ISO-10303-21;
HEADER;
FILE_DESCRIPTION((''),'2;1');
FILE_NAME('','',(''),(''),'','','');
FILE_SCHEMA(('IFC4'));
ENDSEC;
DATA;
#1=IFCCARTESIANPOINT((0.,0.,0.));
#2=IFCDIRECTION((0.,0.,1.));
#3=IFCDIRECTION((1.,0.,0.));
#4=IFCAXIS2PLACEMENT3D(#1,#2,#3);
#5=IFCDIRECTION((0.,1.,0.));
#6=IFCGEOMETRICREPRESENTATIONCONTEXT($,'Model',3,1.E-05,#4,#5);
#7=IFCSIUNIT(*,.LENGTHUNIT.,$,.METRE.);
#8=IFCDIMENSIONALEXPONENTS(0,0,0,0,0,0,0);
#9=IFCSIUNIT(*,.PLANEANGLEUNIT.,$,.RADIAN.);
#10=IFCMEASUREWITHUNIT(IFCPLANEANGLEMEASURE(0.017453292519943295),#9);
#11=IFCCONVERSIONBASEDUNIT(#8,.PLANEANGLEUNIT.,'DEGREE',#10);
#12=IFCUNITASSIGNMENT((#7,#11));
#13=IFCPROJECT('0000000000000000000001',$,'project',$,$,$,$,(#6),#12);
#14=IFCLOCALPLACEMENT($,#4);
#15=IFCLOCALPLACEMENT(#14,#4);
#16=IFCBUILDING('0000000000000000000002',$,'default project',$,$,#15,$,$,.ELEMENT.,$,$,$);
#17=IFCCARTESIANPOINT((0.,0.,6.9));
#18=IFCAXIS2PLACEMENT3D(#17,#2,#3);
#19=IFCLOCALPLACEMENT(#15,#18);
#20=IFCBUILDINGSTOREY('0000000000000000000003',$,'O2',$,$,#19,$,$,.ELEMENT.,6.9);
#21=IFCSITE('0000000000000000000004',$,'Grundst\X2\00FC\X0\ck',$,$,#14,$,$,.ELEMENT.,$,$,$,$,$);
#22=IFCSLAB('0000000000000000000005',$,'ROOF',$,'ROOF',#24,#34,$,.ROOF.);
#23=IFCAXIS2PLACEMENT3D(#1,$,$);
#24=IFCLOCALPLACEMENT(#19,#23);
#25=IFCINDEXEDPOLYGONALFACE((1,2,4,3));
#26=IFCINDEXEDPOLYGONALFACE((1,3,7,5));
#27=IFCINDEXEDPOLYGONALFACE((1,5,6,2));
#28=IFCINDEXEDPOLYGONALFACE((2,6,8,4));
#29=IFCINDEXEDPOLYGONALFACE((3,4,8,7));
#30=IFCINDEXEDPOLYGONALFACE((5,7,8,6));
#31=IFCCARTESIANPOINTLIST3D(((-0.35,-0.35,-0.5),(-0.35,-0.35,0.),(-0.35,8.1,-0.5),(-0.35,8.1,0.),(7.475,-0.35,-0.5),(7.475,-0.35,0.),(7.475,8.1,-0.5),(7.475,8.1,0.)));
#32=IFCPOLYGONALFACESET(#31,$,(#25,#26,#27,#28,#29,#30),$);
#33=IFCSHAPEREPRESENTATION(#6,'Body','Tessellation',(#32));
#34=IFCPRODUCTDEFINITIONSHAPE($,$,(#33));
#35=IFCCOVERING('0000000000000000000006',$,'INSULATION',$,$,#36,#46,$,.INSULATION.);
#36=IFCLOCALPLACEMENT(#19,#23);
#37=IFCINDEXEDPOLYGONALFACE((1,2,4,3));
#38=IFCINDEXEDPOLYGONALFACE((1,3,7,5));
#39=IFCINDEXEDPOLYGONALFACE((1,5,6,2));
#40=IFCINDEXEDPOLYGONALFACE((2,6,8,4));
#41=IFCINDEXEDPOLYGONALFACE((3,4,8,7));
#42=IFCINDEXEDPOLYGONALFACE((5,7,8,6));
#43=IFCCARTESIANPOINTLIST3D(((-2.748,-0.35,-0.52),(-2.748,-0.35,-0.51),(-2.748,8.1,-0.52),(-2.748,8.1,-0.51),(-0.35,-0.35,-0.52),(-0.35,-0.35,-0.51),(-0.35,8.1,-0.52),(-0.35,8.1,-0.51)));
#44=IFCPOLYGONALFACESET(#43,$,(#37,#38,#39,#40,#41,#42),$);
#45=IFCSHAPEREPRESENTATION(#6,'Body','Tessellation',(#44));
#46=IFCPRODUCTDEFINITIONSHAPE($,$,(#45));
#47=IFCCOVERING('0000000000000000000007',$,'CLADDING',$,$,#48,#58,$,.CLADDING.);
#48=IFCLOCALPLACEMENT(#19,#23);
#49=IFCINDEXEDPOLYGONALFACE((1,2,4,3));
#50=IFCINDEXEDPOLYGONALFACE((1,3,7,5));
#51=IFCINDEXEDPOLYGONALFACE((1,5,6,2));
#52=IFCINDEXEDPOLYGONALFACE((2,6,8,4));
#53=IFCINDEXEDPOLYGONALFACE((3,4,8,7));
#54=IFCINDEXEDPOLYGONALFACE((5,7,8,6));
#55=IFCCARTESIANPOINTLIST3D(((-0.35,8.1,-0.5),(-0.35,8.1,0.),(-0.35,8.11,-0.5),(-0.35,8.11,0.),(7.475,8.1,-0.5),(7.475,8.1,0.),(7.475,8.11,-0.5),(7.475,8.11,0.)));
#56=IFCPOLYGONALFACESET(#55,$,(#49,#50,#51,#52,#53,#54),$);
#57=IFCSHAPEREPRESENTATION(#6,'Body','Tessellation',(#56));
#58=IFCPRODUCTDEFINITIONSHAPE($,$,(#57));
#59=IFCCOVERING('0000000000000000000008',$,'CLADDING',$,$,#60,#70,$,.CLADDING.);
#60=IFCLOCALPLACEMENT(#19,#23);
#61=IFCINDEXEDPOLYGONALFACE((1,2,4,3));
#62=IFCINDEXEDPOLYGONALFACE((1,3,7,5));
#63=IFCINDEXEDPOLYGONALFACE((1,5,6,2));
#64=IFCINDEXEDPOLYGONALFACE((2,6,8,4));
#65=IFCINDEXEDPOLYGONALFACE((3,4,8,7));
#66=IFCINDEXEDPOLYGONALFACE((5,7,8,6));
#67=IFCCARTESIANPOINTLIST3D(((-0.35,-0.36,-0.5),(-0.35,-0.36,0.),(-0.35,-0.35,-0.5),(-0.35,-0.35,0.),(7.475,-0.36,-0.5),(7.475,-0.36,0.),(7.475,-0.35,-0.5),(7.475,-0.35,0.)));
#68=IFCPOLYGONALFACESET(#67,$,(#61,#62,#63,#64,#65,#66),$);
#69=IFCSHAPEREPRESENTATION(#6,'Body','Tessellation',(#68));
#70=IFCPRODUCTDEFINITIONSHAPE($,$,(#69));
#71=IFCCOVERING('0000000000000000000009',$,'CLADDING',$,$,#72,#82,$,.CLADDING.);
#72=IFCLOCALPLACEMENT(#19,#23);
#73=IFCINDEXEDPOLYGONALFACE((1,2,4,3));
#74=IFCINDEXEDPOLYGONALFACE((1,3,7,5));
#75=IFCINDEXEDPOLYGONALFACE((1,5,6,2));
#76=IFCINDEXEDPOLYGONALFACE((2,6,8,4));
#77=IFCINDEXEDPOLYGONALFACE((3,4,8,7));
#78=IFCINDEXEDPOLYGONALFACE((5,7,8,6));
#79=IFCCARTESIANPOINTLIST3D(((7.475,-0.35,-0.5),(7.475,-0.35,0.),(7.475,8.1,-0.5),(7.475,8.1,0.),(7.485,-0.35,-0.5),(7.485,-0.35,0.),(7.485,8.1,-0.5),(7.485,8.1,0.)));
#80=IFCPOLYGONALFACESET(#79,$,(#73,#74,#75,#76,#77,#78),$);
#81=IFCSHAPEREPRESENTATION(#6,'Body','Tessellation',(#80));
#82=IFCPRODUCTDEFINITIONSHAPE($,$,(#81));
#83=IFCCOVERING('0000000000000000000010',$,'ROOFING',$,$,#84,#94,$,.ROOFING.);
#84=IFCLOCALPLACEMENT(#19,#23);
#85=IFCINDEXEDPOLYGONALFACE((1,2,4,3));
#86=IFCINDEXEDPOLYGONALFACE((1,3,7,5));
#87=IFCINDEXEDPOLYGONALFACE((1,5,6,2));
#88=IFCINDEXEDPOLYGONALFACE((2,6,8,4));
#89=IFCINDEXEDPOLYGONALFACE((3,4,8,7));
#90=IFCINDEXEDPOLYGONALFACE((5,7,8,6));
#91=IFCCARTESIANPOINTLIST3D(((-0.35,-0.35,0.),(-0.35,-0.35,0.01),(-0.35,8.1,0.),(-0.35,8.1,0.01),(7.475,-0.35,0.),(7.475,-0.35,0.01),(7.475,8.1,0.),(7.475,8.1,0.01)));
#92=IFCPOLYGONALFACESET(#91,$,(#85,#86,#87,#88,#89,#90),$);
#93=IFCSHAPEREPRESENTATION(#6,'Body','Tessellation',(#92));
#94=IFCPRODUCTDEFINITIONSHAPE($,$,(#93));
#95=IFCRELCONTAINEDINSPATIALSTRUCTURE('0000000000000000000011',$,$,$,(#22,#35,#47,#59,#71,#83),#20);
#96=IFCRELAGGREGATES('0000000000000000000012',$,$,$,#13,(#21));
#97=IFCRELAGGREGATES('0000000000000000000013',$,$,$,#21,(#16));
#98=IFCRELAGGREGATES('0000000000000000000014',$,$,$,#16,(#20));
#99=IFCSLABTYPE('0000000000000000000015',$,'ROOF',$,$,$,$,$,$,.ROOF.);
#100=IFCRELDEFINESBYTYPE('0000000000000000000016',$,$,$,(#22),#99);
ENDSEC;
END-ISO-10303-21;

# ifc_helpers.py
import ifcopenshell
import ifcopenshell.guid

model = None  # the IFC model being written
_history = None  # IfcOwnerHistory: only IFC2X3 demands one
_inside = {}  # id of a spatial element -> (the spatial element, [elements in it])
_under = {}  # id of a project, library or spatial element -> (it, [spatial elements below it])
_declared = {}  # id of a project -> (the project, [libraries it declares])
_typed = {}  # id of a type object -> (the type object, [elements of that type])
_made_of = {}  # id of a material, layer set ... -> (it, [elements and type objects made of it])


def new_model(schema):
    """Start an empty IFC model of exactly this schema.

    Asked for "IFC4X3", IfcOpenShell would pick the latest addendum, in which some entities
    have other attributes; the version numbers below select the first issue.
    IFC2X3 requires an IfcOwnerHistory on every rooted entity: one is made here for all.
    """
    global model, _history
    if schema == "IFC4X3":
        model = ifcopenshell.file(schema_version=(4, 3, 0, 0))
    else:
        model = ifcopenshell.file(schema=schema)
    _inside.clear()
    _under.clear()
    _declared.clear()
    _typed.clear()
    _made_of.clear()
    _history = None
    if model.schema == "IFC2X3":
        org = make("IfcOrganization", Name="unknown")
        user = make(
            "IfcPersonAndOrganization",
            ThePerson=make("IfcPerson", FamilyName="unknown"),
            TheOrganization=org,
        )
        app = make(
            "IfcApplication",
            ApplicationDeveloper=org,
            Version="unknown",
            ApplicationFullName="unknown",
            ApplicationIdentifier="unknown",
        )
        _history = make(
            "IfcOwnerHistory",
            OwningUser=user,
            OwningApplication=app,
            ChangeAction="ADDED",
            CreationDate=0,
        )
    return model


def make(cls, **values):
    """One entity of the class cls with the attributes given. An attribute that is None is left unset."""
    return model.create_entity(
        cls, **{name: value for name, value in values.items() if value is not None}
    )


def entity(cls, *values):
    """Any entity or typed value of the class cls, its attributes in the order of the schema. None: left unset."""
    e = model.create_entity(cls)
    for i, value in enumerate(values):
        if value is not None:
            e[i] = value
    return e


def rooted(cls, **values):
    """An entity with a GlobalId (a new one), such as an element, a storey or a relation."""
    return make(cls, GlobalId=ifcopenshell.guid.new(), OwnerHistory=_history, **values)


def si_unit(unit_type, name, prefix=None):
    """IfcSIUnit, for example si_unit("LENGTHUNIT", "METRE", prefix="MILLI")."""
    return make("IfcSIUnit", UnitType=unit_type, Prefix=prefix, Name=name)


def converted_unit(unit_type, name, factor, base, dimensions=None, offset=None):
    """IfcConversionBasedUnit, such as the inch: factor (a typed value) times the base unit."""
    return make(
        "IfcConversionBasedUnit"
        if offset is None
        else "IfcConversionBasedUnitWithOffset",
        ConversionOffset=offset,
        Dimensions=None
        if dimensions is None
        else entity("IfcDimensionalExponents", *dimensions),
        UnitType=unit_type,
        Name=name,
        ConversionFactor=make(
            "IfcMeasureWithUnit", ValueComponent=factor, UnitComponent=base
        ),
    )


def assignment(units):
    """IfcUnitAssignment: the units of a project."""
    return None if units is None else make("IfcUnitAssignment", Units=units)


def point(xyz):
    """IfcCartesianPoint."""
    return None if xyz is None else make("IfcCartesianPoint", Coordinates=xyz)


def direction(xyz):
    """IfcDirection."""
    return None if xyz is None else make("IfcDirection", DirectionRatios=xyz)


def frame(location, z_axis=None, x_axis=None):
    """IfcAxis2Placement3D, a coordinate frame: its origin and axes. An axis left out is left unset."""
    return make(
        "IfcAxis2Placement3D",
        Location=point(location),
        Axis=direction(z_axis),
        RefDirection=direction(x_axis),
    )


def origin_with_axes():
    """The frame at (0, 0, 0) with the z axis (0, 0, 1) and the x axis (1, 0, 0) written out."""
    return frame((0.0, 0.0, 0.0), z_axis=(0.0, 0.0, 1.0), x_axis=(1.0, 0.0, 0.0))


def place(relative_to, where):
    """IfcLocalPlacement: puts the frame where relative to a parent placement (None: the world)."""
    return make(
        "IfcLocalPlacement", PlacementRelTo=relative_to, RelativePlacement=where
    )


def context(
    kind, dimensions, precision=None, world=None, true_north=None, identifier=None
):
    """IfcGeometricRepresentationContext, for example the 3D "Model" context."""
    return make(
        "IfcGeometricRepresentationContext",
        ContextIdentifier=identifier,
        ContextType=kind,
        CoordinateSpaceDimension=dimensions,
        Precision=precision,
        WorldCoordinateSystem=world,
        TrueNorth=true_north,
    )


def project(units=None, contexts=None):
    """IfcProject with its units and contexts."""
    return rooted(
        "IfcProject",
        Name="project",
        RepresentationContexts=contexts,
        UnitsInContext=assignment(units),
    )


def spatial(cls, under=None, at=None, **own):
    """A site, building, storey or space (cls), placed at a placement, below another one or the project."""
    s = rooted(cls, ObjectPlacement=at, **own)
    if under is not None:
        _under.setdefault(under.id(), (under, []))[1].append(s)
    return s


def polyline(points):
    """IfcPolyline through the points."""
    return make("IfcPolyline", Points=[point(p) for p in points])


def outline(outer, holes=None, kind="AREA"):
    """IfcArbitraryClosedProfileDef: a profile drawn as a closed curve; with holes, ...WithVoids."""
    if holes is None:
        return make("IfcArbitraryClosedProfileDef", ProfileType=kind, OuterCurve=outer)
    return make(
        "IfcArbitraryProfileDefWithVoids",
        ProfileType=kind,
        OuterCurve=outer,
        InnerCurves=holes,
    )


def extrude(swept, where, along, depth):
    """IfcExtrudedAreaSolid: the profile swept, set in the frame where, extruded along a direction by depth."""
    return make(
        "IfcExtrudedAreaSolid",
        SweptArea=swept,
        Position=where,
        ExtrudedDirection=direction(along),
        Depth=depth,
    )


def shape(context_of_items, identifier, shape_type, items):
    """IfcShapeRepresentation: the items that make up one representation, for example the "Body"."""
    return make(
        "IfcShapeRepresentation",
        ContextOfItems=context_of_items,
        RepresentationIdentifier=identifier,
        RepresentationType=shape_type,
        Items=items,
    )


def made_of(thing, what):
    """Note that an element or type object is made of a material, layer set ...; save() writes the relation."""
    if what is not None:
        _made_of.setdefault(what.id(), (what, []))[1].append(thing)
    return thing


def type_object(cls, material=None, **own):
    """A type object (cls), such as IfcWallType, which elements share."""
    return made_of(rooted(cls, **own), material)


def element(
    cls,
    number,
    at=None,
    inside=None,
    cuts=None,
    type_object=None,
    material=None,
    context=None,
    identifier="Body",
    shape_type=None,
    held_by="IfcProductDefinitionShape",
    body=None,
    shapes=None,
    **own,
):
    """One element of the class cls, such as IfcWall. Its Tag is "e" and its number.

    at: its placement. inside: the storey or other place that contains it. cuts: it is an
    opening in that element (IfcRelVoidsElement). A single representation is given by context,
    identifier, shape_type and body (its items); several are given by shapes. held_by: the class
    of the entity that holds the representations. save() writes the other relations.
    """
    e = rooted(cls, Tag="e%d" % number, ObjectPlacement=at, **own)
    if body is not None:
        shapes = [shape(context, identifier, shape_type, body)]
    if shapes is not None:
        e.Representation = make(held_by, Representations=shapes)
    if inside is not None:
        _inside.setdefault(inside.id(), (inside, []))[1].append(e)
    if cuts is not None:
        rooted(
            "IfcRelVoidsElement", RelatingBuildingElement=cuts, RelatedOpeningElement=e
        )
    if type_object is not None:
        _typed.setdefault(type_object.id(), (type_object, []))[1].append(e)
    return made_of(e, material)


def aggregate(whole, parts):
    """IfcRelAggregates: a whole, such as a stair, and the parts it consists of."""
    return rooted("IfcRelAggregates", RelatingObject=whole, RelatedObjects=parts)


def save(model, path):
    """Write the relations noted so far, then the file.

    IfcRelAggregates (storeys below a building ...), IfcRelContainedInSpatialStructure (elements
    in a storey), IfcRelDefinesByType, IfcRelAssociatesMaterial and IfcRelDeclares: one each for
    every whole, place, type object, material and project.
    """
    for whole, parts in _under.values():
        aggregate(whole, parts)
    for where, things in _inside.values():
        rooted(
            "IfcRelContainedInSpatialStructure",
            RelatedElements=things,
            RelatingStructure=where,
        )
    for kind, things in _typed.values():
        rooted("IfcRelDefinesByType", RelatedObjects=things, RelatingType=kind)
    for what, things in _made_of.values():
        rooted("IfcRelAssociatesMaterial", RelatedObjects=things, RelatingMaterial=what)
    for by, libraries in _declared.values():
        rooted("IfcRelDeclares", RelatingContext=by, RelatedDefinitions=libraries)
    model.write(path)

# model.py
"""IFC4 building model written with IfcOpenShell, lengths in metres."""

from ifc_helpers import new_model, entity, si_unit, converted_unit, direction, frame, origin_with_axes, place, context, project, spatial, polyline, outline, extrude, type_object, element, save


model = new_model("IFC4")

# Units and contexts
model_context = context("Model", 3, precision=1e-05, world=origin_with_axes(), true_north=direction((0.0, 1.0, 0.0)))
ifc_project = project(units=[si_unit("LENGTHUNIT", "METRE"), converted_unit("PLANEANGLEUNIT", "DEGREE", entity("IfcPlaneAngleMeasure", 0.017453292519943295), si_unit("PLANEANGLEUNIT", "RADIAN"), dimensions=[0, 0, 0, 0, 0, 0, 0])], contexts=[model_context])

# Site, building, storey
site_placement = place(None, origin_with_axes())
site = spatial("IfcSite", under=ifc_project, at=site_placement, Name="Grundstück", CompositionType="ELEMENT")
building_placement = place(site_placement, origin_with_axes())
building = spatial("IfcBuilding", under=site, at=building_placement, Name="default project", CompositionType="ELEMENT")
storey_placement = place(building_placement, frame((0.0, 0.0, 6.9), z_axis=(0.0, 0.0, 1.0), x_axis=(1.0, 0.0, 0.0)))
storey = spatial("IfcBuildingStorey", under=building, at=storey_placement, Name="O2", CompositionType="ELEMENT", Elevation=6.9)

# Slab
slab_type = type_object("IfcSlabType", Name="ROOF", PredefinedType="ROOF")
slab_placement = place(storey_placement, frame((0.0, 0.0, -0.5), z_axis=(0.0, 0.0, 1.0), x_axis=(1.0, 0.0, 0.0)))
element("IfcSlab", 1, at=slab_placement, inside=storey, type_object=slab_type, Name="ROOF", ObjectType="ROOF", PredefinedType="ROOF", context=model_context, shape_type="SweptSolid", body=[
    extrude(outline(polyline([(7.475, 8.1), (-0.35, 8.1), (-0.35, -0.35), (7.475, -0.35), (7.475, 8.1)])), origin_with_axes(), (0.0, 0.0, 1.0), 0.5),
])

# Coverings
placement = place(storey_placement, frame((0.0, 0.0, -0.5), z_axis=(0.0, 0.0, 1.0), x_axis=(1.0, 0.0, 0.0)))
covering_1_placement = place(placement, frame((0.0, 0.0, -0.01), z_axis=(0.0, 0.0, 1.0), x_axis=(1.0, 0.0, 0.0)))
element("IfcCovering", 2, at=covering_1_placement, inside=storey, Name="INSULATION", PredefinedType="INSULATION", context=model_context, shape_type="SweptSolid", body=[
    extrude(outline(polyline([(-0.35, 8.1), (-2.748, 8.1), (-2.748, -0.35), (-0.35, -0.35), (-0.35, 8.1)])), frame((0.0, 0.0, -0.01), z_axis=(0.0, 0.0, 1.0), x_axis=(1.0, 0.0, 0.0)), (0.0, 0.0, 1.0), 0.01),
])
covering_2_placement = place(slab_placement, origin_with_axes())
element("IfcCovering", 3, at=covering_2_placement, inside=storey, Name="CLADDING", PredefinedType="CLADDING", context=model_context, shape_type="SweptSolid", body=[
    extrude(outline(polyline([(7.475, 8.11), (-0.35, 8.11), (-0.35, 8.1), (7.475, 8.1), (7.475, 8.11)])), origin_with_axes(), (0.0, 0.0, 1.0), 0.5),
])
covering_3_placement = place(slab_placement, origin_with_axes())
element("IfcCovering", 4, at=covering_3_placement, inside=storey, Name="CLADDING", PredefinedType="CLADDING", context=model_context, shape_type="SweptSolid", body=[
    extrude(outline(polyline([(-0.35, -0.36), (7.475, -0.36), (7.475, -0.35), (-0.35, -0.35), (-0.35, -0.36)])), origin_with_axes(), (0.0, 0.0, 1.0), 0.5),
])
covering_4_placement = place(slab_placement, origin_with_axes())
element("IfcCovering", 5, at=covering_4_placement, inside=storey, Name="CLADDING", PredefinedType="CLADDING", context=model_context, shape_type="SweptSolid", body=[
    extrude(outline(polyline([(7.485, -0.35), (7.485, 8.1), (7.475, 8.1), (7.475, -0.35), (7.485, -0.35)])), origin_with_axes(), (0.0, 0.0, 1.0), 0.5),
])
covering_5_placement = place(slab_placement, frame((0.0, 0.0, 0.25), z_axis=(0.0, 0.0, 1.0), x_axis=(1.0, 0.0, 0.0)))
element("IfcCovering", 6, at=covering_5_placement, inside=storey, Name="ROOFING", PredefinedType="ROOFING", context=model_context, shape_type="SweptSolid", body=[
    extrude(outline(polyline([(7.475, 8.1), (-0.35, 8.1), (-0.35, -0.35), (7.475, -0.35), (7.475, 8.1)])), frame((0.0, 0.0, 0.25), z_axis=(0.0, 0.0, 1.0), x_axis=(1.0, 0.0, 0.0)), (0.0, 0.0, 1.0), 0.01),
])

save(model, "model.ifc")
